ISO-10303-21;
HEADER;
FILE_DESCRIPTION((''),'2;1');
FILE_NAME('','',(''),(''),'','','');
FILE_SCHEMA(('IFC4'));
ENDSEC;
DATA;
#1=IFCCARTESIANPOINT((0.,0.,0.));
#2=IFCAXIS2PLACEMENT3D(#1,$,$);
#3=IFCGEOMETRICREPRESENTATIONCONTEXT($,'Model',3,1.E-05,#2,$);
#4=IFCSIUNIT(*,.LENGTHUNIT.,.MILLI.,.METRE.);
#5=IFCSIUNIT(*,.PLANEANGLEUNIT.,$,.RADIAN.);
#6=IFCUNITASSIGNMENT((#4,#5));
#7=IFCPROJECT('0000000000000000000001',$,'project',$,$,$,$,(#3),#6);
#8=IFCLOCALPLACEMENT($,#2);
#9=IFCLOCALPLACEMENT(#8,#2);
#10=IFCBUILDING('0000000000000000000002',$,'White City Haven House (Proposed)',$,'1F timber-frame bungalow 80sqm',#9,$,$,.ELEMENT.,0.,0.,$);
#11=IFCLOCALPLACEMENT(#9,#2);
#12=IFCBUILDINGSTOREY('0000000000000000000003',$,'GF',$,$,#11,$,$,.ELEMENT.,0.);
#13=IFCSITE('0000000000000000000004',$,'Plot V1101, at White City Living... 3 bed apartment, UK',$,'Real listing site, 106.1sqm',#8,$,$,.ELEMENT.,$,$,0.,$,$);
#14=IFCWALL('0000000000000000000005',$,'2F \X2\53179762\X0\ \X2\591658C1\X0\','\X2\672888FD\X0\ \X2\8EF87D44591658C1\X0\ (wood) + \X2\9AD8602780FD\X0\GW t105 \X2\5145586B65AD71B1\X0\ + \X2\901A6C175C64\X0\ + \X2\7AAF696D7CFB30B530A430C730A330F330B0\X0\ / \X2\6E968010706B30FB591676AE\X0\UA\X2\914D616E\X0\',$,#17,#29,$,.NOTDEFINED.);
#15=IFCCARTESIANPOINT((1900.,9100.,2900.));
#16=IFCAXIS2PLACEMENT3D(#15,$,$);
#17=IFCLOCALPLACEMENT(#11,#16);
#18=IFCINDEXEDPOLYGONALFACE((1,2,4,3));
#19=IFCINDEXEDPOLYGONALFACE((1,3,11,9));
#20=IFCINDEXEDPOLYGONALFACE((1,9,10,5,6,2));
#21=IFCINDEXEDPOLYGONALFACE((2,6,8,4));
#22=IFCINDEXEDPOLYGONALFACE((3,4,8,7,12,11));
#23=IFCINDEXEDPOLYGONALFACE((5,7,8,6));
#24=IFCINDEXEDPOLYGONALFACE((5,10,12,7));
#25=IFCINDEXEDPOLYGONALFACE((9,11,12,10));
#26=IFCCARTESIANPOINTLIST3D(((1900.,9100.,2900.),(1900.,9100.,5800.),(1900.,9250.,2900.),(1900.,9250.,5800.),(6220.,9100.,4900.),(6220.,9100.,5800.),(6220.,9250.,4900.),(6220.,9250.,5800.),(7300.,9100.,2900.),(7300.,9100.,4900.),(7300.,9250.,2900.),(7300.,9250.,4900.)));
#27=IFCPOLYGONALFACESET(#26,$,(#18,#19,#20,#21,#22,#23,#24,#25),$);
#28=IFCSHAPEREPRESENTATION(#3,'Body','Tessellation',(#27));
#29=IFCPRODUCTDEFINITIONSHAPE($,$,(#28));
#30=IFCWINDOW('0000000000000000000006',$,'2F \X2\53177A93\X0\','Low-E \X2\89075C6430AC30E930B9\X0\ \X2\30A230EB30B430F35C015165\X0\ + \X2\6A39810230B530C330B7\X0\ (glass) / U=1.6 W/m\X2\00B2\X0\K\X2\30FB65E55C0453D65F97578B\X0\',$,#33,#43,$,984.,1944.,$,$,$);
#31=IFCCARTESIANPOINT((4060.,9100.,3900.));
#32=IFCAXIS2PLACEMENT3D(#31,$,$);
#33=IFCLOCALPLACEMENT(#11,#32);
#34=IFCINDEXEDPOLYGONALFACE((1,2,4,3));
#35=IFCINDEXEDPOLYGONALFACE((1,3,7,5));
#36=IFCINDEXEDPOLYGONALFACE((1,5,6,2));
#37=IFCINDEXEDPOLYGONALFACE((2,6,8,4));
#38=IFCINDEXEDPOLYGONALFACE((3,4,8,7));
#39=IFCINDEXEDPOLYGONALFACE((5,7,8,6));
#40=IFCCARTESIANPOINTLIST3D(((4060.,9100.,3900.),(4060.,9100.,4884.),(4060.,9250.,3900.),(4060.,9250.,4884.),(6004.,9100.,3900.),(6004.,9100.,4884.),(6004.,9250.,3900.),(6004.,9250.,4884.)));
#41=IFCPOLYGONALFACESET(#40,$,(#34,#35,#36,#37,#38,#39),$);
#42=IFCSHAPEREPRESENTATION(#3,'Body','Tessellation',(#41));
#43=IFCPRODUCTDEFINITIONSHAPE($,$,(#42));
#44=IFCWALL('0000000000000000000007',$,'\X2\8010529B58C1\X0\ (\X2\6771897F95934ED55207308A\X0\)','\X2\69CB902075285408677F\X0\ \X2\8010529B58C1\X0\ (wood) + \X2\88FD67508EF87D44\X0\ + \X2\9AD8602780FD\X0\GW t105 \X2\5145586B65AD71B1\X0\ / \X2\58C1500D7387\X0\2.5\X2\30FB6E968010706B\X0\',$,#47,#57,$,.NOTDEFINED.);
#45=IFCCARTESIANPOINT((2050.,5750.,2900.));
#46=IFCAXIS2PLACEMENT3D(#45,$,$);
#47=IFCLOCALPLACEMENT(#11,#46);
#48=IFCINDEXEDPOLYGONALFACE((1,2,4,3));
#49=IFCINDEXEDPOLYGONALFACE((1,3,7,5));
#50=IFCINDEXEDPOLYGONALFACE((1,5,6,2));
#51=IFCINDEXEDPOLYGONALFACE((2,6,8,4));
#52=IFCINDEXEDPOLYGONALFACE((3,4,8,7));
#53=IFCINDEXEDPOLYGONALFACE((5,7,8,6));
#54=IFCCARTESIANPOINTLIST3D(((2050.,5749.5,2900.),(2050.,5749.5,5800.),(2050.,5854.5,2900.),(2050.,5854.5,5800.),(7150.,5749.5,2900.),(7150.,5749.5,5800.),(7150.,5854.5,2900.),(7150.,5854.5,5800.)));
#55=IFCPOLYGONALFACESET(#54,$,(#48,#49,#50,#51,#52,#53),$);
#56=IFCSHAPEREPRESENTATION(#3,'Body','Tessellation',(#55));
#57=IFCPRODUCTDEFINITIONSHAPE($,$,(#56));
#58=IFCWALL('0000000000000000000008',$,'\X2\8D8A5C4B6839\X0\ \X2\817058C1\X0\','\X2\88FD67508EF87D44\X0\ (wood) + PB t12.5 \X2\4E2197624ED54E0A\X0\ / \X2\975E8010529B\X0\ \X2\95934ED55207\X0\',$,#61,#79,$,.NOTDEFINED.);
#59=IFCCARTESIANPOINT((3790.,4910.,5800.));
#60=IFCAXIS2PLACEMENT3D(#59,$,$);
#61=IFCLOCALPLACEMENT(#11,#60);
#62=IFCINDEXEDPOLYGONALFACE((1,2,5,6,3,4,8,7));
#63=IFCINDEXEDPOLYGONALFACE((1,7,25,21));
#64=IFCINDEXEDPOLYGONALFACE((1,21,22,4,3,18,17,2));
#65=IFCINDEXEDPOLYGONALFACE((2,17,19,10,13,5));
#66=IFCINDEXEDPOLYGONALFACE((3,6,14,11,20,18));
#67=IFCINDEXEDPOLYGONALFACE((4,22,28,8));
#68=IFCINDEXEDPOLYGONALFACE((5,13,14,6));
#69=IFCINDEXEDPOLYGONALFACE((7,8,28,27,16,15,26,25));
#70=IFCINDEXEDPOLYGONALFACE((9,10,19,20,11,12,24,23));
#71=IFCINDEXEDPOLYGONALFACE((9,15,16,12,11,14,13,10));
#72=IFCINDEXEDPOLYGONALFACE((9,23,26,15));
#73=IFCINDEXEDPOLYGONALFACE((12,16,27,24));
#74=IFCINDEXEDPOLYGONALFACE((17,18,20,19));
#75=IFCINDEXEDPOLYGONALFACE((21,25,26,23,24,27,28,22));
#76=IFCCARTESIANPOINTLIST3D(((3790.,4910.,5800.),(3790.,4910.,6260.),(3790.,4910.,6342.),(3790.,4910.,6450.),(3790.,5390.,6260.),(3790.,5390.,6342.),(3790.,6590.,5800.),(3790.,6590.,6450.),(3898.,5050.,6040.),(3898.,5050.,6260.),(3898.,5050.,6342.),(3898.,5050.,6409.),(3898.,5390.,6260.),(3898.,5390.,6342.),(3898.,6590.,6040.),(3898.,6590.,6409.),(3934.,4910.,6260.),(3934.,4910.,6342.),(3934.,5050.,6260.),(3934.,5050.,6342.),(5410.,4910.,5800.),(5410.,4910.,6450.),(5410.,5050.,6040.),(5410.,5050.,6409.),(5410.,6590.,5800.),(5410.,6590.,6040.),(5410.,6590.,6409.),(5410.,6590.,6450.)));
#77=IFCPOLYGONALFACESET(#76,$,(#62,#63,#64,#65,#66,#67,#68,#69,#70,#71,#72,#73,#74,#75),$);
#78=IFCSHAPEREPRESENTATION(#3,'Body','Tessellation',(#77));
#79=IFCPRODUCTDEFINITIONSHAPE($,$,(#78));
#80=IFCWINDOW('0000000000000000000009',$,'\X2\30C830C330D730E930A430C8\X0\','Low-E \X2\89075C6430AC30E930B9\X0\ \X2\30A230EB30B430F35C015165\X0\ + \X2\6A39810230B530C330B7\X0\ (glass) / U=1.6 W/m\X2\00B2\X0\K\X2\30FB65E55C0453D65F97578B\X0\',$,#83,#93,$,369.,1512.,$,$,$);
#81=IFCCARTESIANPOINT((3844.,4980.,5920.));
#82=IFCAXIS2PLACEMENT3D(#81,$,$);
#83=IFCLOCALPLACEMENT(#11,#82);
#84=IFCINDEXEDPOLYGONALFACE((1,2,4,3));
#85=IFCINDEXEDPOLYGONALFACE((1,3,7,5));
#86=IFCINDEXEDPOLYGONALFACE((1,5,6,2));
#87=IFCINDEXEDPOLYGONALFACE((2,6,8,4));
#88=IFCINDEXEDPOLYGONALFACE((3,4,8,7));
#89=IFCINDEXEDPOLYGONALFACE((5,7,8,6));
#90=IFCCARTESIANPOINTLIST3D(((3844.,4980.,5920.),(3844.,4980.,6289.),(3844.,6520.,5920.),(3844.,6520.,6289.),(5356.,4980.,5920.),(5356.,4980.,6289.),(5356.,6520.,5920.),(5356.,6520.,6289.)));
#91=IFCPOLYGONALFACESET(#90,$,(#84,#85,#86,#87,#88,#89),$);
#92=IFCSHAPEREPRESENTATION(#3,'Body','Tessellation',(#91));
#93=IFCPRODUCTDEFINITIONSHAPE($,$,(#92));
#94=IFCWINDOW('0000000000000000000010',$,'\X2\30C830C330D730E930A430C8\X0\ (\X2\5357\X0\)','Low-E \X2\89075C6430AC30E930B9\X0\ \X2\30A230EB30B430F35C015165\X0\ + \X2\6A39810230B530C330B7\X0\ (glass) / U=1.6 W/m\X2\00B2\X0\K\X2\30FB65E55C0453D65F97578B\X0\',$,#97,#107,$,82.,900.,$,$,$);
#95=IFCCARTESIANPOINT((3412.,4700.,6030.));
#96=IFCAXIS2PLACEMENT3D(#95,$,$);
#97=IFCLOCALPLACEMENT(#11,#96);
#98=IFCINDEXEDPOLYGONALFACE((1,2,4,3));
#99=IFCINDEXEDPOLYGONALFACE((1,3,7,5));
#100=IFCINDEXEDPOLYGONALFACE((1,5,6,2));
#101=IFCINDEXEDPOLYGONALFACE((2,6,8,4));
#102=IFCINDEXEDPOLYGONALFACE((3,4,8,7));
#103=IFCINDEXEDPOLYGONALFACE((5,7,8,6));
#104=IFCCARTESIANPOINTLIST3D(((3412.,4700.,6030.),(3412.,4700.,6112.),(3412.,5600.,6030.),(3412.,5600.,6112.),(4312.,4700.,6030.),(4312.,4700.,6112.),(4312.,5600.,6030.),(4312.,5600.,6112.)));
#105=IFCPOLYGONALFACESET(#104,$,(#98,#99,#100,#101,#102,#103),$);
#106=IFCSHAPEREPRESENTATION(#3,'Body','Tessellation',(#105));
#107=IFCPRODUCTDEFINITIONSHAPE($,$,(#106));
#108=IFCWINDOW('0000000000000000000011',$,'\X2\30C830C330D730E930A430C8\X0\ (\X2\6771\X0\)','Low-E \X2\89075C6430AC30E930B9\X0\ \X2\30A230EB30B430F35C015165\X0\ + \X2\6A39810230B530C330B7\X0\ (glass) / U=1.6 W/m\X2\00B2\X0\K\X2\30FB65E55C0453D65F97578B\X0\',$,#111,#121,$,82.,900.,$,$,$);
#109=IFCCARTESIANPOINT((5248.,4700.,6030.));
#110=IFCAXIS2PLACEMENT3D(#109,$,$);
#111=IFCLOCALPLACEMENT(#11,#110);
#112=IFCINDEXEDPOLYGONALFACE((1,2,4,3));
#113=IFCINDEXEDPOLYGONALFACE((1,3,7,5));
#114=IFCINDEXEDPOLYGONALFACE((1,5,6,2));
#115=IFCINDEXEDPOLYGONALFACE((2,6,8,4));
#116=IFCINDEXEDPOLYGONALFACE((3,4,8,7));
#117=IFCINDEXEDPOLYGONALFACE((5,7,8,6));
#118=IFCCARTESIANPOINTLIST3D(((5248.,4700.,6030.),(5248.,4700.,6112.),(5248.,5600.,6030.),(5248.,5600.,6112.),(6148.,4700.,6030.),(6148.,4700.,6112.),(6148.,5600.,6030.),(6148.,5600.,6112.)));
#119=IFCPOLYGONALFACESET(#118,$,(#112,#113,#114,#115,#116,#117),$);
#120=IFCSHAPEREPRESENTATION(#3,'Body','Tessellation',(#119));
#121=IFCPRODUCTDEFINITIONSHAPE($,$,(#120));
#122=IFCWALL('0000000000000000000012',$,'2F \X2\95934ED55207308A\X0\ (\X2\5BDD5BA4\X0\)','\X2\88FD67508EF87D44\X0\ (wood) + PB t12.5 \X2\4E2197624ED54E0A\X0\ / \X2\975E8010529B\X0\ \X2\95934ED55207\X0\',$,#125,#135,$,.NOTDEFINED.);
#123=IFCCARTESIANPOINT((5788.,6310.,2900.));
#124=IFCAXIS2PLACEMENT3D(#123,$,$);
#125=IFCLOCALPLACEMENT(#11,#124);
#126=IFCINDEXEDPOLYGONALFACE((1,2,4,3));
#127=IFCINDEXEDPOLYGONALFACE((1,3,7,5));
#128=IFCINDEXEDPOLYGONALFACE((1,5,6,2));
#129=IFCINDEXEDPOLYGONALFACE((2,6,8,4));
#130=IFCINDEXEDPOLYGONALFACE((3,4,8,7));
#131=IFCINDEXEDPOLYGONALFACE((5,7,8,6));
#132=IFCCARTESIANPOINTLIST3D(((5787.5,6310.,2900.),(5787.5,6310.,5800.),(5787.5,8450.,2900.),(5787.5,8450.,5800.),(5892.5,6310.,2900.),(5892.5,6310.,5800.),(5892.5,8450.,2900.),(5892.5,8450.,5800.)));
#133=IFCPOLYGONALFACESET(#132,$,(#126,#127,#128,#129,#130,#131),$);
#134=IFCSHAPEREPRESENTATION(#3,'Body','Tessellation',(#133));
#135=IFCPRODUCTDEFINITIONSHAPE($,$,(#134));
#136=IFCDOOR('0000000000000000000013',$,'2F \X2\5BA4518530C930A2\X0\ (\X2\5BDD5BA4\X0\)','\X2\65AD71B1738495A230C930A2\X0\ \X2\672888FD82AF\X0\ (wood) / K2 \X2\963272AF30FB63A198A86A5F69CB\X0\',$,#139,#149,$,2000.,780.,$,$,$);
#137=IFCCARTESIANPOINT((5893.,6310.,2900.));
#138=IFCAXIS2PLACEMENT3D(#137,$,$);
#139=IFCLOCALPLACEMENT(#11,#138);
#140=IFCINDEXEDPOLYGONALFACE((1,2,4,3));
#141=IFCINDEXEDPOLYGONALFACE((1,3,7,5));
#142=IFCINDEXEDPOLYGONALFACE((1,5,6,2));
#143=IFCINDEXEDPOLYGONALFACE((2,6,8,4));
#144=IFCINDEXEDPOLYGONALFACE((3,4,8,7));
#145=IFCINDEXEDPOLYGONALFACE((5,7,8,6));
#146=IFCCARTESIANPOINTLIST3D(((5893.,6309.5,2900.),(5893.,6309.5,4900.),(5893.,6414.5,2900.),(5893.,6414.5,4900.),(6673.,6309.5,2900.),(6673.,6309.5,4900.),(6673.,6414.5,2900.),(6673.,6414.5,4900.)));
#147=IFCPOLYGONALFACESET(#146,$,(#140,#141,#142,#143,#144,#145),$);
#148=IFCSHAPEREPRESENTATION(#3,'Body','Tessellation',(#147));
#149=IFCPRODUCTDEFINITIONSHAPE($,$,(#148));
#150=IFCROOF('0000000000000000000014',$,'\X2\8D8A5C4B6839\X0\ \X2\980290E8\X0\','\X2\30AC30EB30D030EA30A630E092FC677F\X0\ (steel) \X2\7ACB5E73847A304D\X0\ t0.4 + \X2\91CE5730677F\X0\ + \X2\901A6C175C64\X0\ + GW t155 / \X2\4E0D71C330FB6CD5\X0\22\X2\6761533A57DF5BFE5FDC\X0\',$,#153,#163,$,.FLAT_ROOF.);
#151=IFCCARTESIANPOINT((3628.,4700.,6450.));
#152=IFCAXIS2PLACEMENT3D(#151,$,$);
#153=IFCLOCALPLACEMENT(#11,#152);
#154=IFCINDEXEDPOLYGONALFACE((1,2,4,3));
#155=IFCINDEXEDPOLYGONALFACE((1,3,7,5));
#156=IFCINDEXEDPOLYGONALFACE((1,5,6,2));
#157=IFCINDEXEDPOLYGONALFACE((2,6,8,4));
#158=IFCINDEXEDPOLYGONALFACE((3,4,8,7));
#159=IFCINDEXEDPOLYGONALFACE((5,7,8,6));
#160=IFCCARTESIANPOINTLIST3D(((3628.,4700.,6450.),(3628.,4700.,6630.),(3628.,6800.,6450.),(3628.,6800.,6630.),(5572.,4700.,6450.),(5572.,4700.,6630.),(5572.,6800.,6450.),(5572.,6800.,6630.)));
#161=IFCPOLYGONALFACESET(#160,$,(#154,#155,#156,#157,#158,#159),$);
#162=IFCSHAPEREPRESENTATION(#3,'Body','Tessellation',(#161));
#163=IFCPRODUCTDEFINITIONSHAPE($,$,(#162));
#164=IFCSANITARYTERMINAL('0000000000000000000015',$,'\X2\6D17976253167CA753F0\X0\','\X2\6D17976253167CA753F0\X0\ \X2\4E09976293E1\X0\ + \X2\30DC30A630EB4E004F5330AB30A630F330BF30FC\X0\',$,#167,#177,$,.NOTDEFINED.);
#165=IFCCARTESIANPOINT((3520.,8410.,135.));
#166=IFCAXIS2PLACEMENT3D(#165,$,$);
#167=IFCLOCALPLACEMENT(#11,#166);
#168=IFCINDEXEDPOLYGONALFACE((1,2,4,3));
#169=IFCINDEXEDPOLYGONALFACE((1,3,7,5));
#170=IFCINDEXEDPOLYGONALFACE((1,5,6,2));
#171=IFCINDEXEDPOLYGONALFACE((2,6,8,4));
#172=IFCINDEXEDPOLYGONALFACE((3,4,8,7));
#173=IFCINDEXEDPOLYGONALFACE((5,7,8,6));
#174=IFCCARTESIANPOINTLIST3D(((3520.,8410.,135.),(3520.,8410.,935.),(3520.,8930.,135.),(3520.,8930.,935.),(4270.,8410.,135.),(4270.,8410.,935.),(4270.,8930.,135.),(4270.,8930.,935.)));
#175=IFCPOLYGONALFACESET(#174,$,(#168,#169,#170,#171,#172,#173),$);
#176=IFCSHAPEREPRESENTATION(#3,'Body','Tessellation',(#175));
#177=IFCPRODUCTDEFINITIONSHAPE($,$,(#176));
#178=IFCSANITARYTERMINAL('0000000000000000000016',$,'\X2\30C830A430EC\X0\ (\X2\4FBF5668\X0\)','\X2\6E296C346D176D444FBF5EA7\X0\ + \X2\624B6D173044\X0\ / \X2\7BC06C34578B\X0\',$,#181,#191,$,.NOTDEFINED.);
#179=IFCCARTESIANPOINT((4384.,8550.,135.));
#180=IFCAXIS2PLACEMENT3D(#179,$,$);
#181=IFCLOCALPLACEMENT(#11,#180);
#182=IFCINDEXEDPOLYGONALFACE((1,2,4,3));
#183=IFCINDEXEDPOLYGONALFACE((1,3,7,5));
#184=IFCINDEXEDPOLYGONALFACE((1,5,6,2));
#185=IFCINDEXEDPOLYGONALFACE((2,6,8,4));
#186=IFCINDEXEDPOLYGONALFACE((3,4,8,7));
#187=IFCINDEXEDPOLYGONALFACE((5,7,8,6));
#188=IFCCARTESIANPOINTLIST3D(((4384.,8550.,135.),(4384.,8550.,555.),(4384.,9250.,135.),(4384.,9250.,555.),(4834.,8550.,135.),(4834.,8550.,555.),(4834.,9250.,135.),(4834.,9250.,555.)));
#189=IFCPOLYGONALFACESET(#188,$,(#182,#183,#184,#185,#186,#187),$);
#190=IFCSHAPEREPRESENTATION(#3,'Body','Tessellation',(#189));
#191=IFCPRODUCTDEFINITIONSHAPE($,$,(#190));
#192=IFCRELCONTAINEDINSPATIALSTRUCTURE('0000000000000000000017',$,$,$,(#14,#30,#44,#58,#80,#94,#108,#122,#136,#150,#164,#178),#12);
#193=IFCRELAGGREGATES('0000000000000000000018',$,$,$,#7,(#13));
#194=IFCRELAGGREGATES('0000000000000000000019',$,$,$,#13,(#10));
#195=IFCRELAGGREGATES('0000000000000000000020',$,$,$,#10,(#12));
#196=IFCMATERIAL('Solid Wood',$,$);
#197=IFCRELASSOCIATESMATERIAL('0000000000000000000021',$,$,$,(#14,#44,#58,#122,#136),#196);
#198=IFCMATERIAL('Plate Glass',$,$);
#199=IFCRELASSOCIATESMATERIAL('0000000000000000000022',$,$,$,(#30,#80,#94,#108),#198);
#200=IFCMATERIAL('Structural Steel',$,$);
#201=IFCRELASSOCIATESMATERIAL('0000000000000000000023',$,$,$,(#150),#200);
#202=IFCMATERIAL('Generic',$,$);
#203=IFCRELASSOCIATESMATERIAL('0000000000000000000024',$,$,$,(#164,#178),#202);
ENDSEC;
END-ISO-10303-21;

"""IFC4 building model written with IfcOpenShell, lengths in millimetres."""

from ifc_helpers import new_model, si_unit, frame, frame_2d, origin, place, context, project, spatial, rectangle, extrude, material, element, fill, save


model = new_model("IFC4")

# Units and contexts
model_context = context("Model", 3, precision=1e-05, world=origin())
ifc_project = project(units=[si_unit("LENGTHUNIT", "METRE", prefix="MILLI"), si_unit("PLANEANGLEUNIT", "RADIAN")], contexts=[model_context])

# Site, building, storey
site_placement = place(None, origin())
site = spatial("IfcSite", under=ifc_project, at=site_placement, Name="Plot V1101, at White City Living... 3 bed apartment, UK", ObjectType="Real listing site, 106.1sqm", CompositionType="ELEMENT", RefElevation=0.0)
building_placement = place(site_placement, origin())
building = spatial("IfcBuilding", under=site, at=building_placement, Name="White City Haven House (Proposed)", ObjectType="1F timber-frame bungalow 80sqm", CompositionType="ELEMENT", ElevationOfRefHeight=0.0, ElevationOfTerrain=0.0)
storey_placement = place(building_placement, origin())
storey = spatial("IfcBuildingStorey", under=building, at=storey_placement, Name="GF", CompositionType="ELEMENT", Elevation=0.0)

# Wall, opening, window
ifc_material_1 = material(Name="Solid Wood")
wall_1_placement = place(storey_placement, frame((1900.0, 9100.0, 2900.0)))
wall_1 = element("IfcWall", 1, at=wall_1_placement, inside=storey, material=ifc_material_1, Name="2F 北面 外壁", Description="木製 軸組外壁 (wood) + 高性能GW t105 充填断熱 + 通気層 + 窯業系サイディング / 準耐火・外皮UA配慮", PredefinedType="NOTDEFINED", context=model_context, shape_type="SweptSolid", body=[
    extrude(rectangle(XDim=5400.0, YDim=150.0, at=frame_2d((2700.0, 75.0))), frame((1900.0, 9100.0, 2900.0)), (0.0, 0.0, 1.0), 2900.0),
])
opening_1_placement = place(storey_placement, frame((4060.0, 9100.0, 3900.0)))
opening_1 = element("IfcOpeningElement", 2, at=opening_1_placement, cuts=wall_1, PredefinedType="NOTDEFINED", context=model_context, shape_type="SweptSolid", body=[
    extrude(rectangle(XDim=1944.0, YDim=150.0, at=frame_2d((972.0, 75.0))), frame((4060.0, 9100.0, 3900.0)), (0.0, 0.0, 1.0), 984.0),
])
ifc_material_2 = material(Name="Plate Glass")
window_1_placement = place(storey_placement, frame((4060.0, 9100.0, 3900.0)))
window_1 = element("IfcWindow", 3, at=window_1_placement, inside=storey, material=ifc_material_2, Name="2F 北窓", Description="Low-E 複層ガラス アルゴン封入 + 樹脂サッシ (glass) / U=1.6 W/m²K・日射取得型", OverallHeight=984.0, OverallWidth=1944.0, context=model_context, shape_type="SweptSolid", body=[
    extrude(rectangle(XDim=1944.0, YDim=150.0, at=frame_2d((972.0, 75.0))), frame((4060.0, 9100.0, 3900.0)), (0.0, 0.0, 1.0), 984.0),
])
fill(opening_1, window_1)

# Wall
wall_2_placement = place(storey_placement, frame((2050.0, 5750.0, 2900.0)))
element("IfcWall", 4, at=wall_2_placement, inside=storey, material=ifc_material_1, Name="耐力壁 (東西間仕切り)", Description="構造用合板 耐力壁 (wood) + 製材軸組 + 高性能GW t105 充填断熱 / 壁倍率2.5・準耐火", PredefinedType="NOTDEFINED", context=model_context, shape_type="SweptSolid", body=[
    extrude(rectangle(XDim=5100.0, YDim=105.0, at=frame_2d((2550.0, 52.0))), frame((2050.0, 5750.0, 2900.0)), (0.0, 0.0, 1.0), 2900.0),
])

# Wall, openings, windows
wall_3_placement = place(storey_placement, frame((3790.0, 4910.0, 5800.0)))
wall_3 = element("IfcWall", 5, at=wall_3_placement, inside=storey, material=ifc_material_1, Name="越屋根 腰壁", Description="製材軸組 (wood) + PB t12.5 両面仕上 / 非耐力 間仕切", PredefinedType="NOTDEFINED", context=model_context, shape_type="SweptSolid", body=[
    extrude(rectangle(XDim=1620.0, YDim=1680.0, at=frame_2d((810.0, 840.0))), frame((3790.0, 4910.0, 5800.0)), (0.0, 0.0, 1.0), 650.0),
])
opening_2_placement = place(storey_placement, frame((3844.0, 4980.0, 5920.0)))
opening_2 = element("IfcOpeningElement", 6, at=opening_2_placement, cuts=wall_3, PredefinedType="NOTDEFINED", context=model_context, shape_type="SweptSolid", body=[
    extrude(rectangle(XDim=1512.0, YDim=1540.0, at=frame_2d((756.0, 770.0))), frame((3844.0, 4980.0, 5920.0)), (0.0, 0.0, 1.0), 369.0),
])
opening_3_placement = place(storey_placement, frame((3412.0, 4700.0, 6030.0)))
opening_3 = element("IfcOpeningElement", 7, at=opening_3_placement, cuts=wall_3, PredefinedType="NOTDEFINED", context=model_context, shape_type="SweptSolid", body=[
    extrude(rectangle(XDim=900.0, YDim=900.0, at=frame_2d((450.0, 450.0))), frame((3412.0, 4700.0, 6030.0)), (0.0, 0.0, 1.0), 82.0),
])
opening_4_placement = place(storey_placement, frame((5248.0, 4700.0, 6030.0)))
opening_4 = element("IfcOpeningElement", 8, at=opening_4_placement, cuts=wall_3, PredefinedType="NOTDEFINED", context=model_context, shape_type="SweptSolid", body=[
    extrude(rectangle(XDim=900.0, YDim=900.0, at=frame_2d((450.0, 450.0))), frame((5248.0, 4700.0, 6030.0)), (0.0, 0.0, 1.0), 82.0),
])
window_2_placement = place(storey_placement, frame((3844.0, 4980.0, 5920.0)))
window_2 = element("IfcWindow", 9, at=window_2_placement, inside=storey, material=ifc_material_2, Name="トップライト", Description="Low-E 複層ガラス アルゴン封入 + 樹脂サッシ (glass) / U=1.6 W/m²K・日射取得型", OverallHeight=369.0, OverallWidth=1512.0, context=model_context, shape_type="SweptSolid", body=[
    extrude(rectangle(XDim=1512.0, YDim=1540.0, at=frame_2d((756.0, 770.0))), frame((3844.0, 4980.0, 5920.0)), (0.0, 0.0, 1.0), 369.0),
])
fill(opening_2, window_2)
window_3_placement = place(storey_placement, frame((3412.0, 4700.0, 6030.0)))
window_3 = element("IfcWindow", 10, at=window_3_placement, inside=storey, material=ifc_material_2, Name="トップライト (南)", Description="Low-E 複層ガラス アルゴン封入 + 樹脂サッシ (glass) / U=1.6 W/m²K・日射取得型", OverallHeight=82.0, OverallWidth=900.0, context=model_context, shape_type="SweptSolid", body=[
    extrude(rectangle(XDim=900.0, YDim=900.0, at=frame_2d((450.0, 450.0))), frame((3412.0, 4700.0, 6030.0)), (0.0, 0.0, 1.0), 82.0),
])
fill(opening_3, window_3)
window_4_placement = place(storey_placement, frame((5248.0, 4700.0, 6030.0)))
window_4 = element("IfcWindow", 11, at=window_4_placement, inside=storey, material=ifc_material_2, Name="トップライト (東)", Description="Low-E 複層ガラス アルゴン封入 + 樹脂サッシ (glass) / U=1.6 W/m²K・日射取得型", OverallHeight=82.0, OverallWidth=900.0, context=model_context, shape_type="SweptSolid", body=[
    extrude(rectangle(XDim=900.0, YDim=900.0, at=frame_2d((450.0, 450.0))), frame((5248.0, 4700.0, 6030.0)), (0.0, 0.0, 1.0), 82.0),
])
fill(opening_4, window_4)

# Wall
wall_4_placement = place(storey_placement, frame((5788.0, 6310.0, 2900.0)))
element("IfcWall", 12, at=wall_4_placement, inside=storey, material=ifc_material_1, Name="2F 間仕切り (寝室)", Description="製材軸組 (wood) + PB t12.5 両面仕上 / 非耐力 間仕切", PredefinedType="NOTDEFINED", context=model_context, shape_type="SweptSolid", body=[
    extrude(rectangle(XDim=105.0, YDim=2140.0, at=frame_2d((52.0, 1070.0))), frame((5788.0, 6310.0, 2900.0)), (0.0, 0.0, 1.0), 2900.0),
])

# Door
door_placement = place(storey_placement, frame((5893.0, 6310.0, 2900.0)))
element("IfcDoor", 13, at=door_placement, inside=storey, material=ifc_material_1, Name="2F 室内ドア (寝室)", Description="断熱玄関ドア 木製芯 (wood) / K2 防犯・採風機構", OverallHeight=2000.0, OverallWidth=780.0, context=model_context, shape_type="SweptSolid", body=[
    extrude(rectangle(XDim=780.0, YDim=105.0, at=frame_2d((390.0, 52.0))), frame((5893.0, 6310.0, 2900.0)), (0.0, 0.0, 1.0), 2000.0),
])

# Roof
ifc_material_3 = material(Name="Structural Steel")
roof_placement = place(storey_placement, frame((3628.0, 4700.0, 6450.0)))
element("IfcRoof", 14, at=roof_placement, inside=storey, material=ifc_material_3, Name="越屋根 頂部", Description="ガルバリウム鋼板 (steel) 立平葺き t0.4 + 野地板 + 通気層 + GW t155 / 不燃・法22条区域対応", PredefinedType="FLAT_ROOF", context=model_context, shape_type="SweptSolid", body=[
    extrude(rectangle(XDim=1944.0, YDim=2100.0, at=frame_2d((972.0, 1050.0))), frame((3628.0, 4700.0, 6450.0)), (0.0, 0.0, 1.0), 180.0),
])

# Sanitary terminals
ifc_material_4 = material(Name="Generic")
sanitary_terminal_1_placement = place(storey_placement, frame((3520.0, 8410.0, 135.0)))
element("IfcSanitaryTerminal", 15, at=sanitary_terminal_1_placement, inside=storey, material=ifc_material_4, Name="洗面化粧台", Description="洗面化粧台 三面鏡 + ボウル一体カウンター", PredefinedType="NOTDEFINED", context=model_context, shape_type="SweptSolid", body=[
    extrude(rectangle(XDim=750.0, YDim=520.0, at=frame_2d((375.0, 260.0))), frame((3520.0, 8410.0, 135.0)), (0.0, 0.0, 1.0), 800.0),
])
sanitary_terminal_2_placement = place(storey_placement, frame((4384.0, 8550.0, 135.0)))
element("IfcSanitaryTerminal", 16, at=sanitary_terminal_2_placement, inside=storey, material=ifc_material_4, Name="トイレ (便器)", Description="温水洗浄便座 + 手洗い / 節水型", PredefinedType="NOTDEFINED", context=model_context, shape_type="SweptSolid", body=[
    extrude(rectangle(XDim=450.0, YDim=700.0, at=frame_2d((225.0, 350.0))), frame((4384.0, 8550.0, 135.0)), (0.0, 0.0, 1.0), 420.0),
])

save(model, "model.ifc")
